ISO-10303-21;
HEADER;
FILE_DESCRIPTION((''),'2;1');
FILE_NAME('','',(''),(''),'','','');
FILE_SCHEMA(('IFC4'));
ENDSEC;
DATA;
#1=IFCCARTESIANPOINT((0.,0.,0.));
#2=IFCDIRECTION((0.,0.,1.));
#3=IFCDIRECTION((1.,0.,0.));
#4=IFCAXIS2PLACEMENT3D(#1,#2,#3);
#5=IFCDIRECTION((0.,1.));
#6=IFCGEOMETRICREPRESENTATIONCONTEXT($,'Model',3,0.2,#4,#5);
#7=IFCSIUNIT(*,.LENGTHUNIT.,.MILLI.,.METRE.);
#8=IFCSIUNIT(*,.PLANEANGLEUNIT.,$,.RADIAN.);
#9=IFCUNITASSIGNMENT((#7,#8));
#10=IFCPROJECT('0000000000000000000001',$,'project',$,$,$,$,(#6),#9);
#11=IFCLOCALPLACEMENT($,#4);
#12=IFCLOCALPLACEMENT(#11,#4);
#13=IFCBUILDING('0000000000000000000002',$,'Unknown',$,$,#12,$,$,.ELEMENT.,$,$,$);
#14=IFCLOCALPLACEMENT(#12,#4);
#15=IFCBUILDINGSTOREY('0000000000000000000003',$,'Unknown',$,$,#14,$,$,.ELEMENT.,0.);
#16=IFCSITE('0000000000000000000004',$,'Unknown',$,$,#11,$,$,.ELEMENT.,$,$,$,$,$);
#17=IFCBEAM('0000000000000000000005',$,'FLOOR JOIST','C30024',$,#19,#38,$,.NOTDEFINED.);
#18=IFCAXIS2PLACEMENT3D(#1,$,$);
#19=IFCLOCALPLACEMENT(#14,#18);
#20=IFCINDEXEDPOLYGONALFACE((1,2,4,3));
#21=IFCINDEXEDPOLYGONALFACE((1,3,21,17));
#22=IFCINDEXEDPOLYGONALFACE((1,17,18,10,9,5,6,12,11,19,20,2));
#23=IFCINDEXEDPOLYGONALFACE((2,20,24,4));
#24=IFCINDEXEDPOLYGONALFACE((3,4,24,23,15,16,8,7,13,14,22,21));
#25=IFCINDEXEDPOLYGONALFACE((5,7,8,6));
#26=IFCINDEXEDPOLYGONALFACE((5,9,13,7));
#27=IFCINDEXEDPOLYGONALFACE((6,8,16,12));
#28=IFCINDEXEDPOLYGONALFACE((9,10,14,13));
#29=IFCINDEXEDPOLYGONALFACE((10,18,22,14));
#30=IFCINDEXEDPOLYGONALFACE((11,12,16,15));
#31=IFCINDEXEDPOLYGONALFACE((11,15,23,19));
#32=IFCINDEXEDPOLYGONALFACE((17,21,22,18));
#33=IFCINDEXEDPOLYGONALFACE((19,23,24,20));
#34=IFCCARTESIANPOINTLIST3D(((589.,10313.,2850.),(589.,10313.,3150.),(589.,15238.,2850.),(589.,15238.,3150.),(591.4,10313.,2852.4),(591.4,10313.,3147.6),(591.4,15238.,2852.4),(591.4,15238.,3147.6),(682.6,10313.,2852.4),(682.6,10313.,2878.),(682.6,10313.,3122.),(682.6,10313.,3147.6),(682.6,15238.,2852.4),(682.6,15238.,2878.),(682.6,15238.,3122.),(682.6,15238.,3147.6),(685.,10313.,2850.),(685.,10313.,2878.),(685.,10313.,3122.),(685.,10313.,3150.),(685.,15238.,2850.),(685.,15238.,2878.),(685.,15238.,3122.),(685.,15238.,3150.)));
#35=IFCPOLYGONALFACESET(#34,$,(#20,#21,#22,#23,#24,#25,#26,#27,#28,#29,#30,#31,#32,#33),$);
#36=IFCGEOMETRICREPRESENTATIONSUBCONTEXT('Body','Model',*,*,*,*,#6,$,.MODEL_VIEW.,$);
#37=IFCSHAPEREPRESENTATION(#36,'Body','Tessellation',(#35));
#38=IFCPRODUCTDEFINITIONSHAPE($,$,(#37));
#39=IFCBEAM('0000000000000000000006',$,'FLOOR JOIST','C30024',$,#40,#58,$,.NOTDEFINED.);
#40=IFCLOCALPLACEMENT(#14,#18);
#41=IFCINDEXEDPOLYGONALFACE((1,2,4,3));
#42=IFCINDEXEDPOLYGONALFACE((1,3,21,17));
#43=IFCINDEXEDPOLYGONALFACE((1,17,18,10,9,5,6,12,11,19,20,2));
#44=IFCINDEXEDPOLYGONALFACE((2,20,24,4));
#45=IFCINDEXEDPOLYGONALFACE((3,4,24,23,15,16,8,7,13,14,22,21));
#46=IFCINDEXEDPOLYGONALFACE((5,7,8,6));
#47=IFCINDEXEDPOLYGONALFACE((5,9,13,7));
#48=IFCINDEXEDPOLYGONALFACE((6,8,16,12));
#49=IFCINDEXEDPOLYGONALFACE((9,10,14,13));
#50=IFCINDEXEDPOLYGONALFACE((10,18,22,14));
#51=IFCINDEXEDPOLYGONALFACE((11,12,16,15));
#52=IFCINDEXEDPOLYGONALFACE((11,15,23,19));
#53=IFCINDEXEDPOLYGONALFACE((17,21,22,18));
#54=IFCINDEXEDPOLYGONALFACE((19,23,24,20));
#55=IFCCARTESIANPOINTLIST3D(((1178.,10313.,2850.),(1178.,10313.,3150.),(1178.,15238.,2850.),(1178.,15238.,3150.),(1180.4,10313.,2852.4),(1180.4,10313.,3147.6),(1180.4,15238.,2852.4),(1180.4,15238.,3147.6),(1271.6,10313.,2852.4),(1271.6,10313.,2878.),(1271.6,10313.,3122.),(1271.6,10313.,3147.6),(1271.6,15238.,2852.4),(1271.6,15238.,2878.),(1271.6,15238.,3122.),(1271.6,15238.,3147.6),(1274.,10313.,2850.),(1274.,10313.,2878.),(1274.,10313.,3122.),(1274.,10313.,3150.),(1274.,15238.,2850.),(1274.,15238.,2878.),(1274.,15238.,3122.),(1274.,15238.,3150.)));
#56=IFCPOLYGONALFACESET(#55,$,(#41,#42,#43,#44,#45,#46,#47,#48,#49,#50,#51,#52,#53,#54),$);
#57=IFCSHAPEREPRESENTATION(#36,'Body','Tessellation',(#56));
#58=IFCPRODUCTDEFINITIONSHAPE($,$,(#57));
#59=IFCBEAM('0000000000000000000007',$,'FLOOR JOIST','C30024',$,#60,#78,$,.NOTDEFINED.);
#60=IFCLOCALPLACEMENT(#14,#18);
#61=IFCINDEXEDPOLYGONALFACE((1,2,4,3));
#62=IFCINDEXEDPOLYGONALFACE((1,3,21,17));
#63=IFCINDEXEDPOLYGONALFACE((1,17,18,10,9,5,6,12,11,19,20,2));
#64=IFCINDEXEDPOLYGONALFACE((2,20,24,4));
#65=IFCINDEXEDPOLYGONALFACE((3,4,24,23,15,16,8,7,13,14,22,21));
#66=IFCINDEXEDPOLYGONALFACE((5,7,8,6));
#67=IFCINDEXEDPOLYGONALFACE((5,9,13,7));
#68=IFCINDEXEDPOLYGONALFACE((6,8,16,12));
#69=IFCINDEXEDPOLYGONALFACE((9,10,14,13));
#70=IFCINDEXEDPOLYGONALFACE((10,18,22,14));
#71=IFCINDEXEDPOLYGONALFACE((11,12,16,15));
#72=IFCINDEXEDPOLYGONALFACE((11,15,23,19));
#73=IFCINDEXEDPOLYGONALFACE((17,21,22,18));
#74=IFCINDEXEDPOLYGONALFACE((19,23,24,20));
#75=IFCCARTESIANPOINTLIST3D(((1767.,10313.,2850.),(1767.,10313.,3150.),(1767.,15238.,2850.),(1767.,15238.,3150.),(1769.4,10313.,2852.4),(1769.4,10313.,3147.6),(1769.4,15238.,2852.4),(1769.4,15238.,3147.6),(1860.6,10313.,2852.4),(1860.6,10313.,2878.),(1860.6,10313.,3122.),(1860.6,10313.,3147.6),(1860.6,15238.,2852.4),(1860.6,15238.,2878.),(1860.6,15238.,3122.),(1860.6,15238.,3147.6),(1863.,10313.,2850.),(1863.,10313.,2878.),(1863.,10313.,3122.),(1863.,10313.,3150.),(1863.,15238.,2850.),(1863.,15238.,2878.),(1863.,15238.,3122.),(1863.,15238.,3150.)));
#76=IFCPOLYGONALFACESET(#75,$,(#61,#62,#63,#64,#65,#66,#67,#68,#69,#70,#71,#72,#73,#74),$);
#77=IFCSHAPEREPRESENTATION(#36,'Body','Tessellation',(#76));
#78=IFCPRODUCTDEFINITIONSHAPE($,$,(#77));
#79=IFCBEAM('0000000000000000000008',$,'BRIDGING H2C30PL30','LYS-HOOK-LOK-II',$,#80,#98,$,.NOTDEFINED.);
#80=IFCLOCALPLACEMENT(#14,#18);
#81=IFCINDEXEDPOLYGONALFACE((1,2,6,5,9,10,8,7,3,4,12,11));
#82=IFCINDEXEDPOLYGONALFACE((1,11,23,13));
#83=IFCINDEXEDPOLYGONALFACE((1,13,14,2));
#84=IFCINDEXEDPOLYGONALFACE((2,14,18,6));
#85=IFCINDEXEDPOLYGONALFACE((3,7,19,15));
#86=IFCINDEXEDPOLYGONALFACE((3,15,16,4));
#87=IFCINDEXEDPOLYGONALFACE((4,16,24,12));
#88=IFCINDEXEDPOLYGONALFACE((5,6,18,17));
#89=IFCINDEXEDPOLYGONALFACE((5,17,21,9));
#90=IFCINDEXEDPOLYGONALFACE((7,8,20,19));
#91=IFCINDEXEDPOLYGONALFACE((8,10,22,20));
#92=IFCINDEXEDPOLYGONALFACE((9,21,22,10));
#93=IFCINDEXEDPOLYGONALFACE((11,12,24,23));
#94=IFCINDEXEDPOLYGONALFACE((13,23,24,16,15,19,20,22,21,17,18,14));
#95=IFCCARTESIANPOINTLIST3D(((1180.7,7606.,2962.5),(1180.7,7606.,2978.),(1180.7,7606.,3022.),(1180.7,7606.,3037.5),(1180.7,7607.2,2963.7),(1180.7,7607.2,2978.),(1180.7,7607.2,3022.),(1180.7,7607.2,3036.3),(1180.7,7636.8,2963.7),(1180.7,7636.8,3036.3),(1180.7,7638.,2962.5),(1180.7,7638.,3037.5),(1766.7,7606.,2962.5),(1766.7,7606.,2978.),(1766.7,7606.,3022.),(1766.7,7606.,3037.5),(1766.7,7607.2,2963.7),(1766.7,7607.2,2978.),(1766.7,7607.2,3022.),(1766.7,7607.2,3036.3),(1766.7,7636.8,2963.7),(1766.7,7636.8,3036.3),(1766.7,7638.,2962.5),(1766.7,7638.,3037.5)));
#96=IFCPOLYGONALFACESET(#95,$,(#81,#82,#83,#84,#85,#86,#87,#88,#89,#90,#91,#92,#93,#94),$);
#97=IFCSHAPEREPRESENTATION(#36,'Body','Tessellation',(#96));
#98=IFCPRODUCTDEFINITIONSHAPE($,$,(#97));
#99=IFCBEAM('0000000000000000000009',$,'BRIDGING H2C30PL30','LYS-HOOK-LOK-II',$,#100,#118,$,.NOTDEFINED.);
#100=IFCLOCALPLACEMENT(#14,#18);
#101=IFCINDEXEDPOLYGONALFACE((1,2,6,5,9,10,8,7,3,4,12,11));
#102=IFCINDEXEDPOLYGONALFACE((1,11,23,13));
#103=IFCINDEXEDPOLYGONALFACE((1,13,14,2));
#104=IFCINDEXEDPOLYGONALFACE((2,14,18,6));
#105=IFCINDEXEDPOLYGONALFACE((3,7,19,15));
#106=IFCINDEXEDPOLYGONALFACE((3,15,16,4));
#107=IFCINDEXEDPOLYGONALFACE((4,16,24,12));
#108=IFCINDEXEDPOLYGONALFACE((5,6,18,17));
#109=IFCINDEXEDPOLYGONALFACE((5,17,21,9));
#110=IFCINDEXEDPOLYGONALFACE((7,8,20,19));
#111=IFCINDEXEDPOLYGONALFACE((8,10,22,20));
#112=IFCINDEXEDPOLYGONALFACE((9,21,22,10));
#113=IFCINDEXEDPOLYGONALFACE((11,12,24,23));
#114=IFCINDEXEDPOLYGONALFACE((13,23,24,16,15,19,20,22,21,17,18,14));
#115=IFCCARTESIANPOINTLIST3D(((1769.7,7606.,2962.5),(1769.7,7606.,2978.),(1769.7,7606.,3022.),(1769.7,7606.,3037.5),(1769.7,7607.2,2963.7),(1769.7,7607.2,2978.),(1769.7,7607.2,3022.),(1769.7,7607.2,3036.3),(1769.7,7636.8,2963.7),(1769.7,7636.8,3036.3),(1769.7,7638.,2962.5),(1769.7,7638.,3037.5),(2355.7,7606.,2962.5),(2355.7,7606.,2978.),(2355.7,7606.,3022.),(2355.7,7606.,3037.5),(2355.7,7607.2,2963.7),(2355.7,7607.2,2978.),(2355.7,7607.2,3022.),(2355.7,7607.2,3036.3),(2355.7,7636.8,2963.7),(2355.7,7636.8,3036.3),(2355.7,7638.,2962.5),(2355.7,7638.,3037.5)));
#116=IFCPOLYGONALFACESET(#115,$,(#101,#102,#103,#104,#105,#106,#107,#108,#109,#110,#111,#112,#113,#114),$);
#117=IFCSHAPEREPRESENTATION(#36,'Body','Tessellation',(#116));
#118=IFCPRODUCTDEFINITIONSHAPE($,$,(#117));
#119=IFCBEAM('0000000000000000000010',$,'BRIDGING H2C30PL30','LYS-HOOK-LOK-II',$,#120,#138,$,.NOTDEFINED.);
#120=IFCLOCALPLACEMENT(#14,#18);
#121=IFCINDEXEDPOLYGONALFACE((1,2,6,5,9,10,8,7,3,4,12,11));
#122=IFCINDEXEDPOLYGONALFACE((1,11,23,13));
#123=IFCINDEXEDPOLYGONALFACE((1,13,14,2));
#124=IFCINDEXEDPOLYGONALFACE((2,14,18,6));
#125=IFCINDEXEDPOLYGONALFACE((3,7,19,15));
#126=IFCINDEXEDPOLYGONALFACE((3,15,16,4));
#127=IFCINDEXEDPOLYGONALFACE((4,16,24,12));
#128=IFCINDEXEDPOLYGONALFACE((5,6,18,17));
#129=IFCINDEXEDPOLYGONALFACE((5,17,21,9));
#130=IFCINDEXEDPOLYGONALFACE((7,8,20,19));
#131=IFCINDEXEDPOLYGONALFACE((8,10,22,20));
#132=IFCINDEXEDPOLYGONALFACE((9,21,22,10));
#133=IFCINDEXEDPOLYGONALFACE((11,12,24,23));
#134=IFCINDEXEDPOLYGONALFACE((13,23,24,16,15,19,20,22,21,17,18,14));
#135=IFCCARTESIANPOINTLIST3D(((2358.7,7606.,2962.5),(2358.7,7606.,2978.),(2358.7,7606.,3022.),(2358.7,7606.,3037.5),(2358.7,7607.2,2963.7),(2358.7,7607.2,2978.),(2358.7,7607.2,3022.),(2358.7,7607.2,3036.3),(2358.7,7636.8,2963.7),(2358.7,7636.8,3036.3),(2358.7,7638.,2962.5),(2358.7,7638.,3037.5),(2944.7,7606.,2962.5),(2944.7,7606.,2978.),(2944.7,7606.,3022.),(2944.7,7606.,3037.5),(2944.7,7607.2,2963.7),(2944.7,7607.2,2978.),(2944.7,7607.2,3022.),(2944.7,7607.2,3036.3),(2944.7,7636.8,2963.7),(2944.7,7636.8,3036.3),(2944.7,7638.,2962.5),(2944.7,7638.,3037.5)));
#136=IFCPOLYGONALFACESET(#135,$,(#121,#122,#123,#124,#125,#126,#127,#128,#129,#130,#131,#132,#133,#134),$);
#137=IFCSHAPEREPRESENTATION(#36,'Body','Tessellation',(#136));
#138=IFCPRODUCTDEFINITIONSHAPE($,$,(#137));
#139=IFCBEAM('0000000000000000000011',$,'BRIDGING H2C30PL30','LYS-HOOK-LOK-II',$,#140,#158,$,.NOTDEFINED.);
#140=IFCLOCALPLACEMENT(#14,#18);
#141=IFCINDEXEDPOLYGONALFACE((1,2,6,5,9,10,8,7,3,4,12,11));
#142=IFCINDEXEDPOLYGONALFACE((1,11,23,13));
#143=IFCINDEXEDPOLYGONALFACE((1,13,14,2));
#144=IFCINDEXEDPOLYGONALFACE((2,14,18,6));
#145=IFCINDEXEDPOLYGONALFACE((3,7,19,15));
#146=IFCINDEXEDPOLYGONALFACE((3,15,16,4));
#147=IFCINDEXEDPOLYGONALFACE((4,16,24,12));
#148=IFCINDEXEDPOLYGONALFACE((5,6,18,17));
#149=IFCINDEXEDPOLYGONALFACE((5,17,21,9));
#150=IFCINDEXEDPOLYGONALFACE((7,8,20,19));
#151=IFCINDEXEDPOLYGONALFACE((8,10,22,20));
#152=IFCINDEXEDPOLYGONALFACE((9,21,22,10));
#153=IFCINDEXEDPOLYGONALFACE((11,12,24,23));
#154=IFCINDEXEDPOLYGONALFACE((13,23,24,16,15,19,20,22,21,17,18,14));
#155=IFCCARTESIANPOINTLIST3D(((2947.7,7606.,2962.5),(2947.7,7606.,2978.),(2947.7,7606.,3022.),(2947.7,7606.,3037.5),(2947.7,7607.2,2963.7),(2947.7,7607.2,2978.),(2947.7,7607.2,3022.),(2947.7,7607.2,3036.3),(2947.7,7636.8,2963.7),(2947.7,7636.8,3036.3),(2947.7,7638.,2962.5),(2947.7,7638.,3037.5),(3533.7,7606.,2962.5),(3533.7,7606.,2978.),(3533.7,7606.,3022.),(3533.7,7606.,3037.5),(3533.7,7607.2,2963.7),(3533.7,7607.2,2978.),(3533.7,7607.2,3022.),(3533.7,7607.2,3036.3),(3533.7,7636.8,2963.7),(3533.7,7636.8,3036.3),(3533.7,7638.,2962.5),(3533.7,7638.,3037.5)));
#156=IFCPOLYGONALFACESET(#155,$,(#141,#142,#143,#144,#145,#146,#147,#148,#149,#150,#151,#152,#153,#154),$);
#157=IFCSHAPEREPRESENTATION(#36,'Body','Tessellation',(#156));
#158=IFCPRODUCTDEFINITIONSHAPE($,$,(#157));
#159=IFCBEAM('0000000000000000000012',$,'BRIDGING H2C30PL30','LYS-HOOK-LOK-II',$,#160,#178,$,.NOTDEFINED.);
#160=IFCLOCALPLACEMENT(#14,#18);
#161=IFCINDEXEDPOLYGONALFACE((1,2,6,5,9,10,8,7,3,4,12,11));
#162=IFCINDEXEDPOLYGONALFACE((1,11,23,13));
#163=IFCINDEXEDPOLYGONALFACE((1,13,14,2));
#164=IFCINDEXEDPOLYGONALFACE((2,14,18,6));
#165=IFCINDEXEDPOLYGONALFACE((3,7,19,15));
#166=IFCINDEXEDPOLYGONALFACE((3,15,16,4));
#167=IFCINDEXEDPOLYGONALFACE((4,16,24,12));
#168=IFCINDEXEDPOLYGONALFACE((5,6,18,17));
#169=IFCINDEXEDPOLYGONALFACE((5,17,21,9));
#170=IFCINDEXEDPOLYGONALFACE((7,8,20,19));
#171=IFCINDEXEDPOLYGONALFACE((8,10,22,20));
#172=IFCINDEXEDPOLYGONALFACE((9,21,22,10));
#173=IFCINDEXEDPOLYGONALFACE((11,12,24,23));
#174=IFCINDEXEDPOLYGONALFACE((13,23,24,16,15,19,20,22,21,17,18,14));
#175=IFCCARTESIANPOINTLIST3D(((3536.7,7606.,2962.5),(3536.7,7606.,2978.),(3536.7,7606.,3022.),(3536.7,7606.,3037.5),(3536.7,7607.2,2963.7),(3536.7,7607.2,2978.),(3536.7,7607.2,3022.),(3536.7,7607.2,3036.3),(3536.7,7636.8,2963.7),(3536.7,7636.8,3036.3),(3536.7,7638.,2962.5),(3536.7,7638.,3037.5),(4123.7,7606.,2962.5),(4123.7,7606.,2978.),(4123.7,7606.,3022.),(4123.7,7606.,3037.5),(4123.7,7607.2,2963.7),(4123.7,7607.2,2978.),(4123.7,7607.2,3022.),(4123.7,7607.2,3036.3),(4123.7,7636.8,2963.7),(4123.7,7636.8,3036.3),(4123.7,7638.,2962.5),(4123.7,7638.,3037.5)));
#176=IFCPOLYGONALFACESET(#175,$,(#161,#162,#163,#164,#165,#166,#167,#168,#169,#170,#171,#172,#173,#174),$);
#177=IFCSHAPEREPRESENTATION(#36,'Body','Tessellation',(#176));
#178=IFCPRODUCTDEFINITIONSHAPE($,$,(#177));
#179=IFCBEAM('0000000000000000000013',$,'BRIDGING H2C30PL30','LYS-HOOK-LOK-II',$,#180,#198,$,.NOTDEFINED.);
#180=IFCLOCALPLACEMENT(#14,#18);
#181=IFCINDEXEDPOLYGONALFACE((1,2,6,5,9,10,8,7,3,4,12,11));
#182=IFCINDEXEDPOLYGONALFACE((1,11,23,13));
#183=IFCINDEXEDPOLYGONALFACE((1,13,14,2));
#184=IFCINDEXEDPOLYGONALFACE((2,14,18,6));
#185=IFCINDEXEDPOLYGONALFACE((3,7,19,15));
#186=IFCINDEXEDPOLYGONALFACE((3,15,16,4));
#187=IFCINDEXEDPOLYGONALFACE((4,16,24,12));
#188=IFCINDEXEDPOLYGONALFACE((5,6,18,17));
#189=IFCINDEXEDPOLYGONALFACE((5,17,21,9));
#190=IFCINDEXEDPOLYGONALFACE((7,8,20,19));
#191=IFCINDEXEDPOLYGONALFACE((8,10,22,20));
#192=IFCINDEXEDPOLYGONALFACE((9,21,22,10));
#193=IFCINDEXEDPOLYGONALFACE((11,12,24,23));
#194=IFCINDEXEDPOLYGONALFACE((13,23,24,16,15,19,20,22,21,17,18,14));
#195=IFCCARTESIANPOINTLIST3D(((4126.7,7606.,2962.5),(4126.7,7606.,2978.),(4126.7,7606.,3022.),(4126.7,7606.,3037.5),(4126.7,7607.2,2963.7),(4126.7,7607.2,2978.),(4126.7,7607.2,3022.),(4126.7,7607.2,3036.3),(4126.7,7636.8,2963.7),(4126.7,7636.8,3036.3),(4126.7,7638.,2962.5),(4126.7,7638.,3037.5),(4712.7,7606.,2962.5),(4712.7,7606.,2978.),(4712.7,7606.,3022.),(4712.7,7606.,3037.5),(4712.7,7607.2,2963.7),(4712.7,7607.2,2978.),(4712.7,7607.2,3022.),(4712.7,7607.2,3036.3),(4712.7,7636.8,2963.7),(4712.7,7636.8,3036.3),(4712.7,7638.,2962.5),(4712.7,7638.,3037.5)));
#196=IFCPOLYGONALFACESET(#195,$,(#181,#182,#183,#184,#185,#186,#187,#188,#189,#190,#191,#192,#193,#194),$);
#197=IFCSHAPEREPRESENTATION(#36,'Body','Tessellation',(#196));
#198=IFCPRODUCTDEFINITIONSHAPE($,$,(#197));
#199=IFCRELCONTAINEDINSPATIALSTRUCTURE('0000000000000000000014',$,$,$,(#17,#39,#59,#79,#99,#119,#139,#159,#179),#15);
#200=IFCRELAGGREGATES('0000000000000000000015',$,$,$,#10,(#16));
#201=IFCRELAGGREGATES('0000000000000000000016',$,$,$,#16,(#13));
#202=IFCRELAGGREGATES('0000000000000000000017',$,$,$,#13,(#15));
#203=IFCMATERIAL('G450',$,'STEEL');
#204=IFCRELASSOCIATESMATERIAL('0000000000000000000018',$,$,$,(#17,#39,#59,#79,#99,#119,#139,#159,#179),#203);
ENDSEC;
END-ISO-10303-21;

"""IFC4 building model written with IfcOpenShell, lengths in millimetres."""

from ifc_helpers import new_model, si_unit, direction, frame, origin_with_axes, place, context, subcontext, project, spatial, line, indexed_curve, outline, extrude, material, element, save


model = new_model("IFC4")

# Units and contexts
model_context = context("Model", 3, precision=0.2, world=origin_with_axes(), true_north=direction((0.0, 1.0)))
body_context = subcontext(model_context, "Body", "Model", "MODEL_VIEW")
ifc_project = project(units=[si_unit("LENGTHUNIT", "METRE", prefix="MILLI"), si_unit("PLANEANGLEUNIT", "RADIAN")], contexts=[model_context])

# Site, building, storey
site_placement = place(None, origin_with_axes())
site = spatial("IfcSite", under=ifc_project, at=site_placement, Name="Unknown", CompositionType="ELEMENT")
building_placement = place(site_placement, origin_with_axes())
building = spatial("IfcBuilding", under=site, at=building_placement, Name="Unknown", CompositionType="ELEMENT")
storey_placement = place(building_placement, origin_with_axes())
storey = spatial("IfcBuildingStorey", under=building, at=storey_placement, Name="Unknown", CompositionType="ELEMENT", Elevation=0.0)

# Beams
ifc_material_1 = material(Name="G450", Category="STEEL")
for number, where, z_axis, x_axis, name in (
    (1, (637.0, 10313.0, 3000.0), (1.0, 0.0, 0.0), (0.0, 1.0, 0.0), "FLOOR JOIST"),
    (2, (1226.0, 10313.0, 3000.0), (1.0, 0.0, 0.0), (0.0, 1.0, 0.0), "FLOOR JOIST"),
    (3, (1815.0, 10313.0, 3000.0), (1.0, 0.0, 0.0), (0.0, 1.0, 0.0), "FLOOR JOIST"),
):
    element("IfcBeam", number, at=place(storey_placement, frame(where, z_axis=z_axis, x_axis=x_axis)), inside=storey, material=ifc_material_1, Name=name, Description="C30024", PredefinedType="NOTDEFINED", context=body_context, shape_type="SolidModel", body=[
        extrude(outline(indexed_curve([(48.0, -150.0), (48.0, -122.0), (45.6, -122.0), (45.6, -147.6), (-45.6, -147.6), (-45.6, 147.6), (45.6, 147.6), (45.6, 122.0), (48.0, 122.0), (48.0, 150.0), (-48.0, 150.0), (-48.0, -150.0)], segments=[line(1, 2, 3, 4, 5, 6, 7, 8, 9, 10, 11, 12, 1)])), frame((0.0, 0.0, 0.0), z_axis=(-1.0, 0.0, 0.0), x_axis=(0.0, 0.0, 1.0)), (0.0, 0.0, -1.0), 4925.0),
    ])
for number, where, z_axis, x_axis, name in (
    (4, (1180.7, 7622.0, 3000.0), (0.0, -1.0, 0.0), (1.0, 0.0, 0.0), "BRIDGING H2C30PL30"),
    (5, (1769.7, 7622.0, 3000.0), (0.0, -1.0, 0.0), (1.0, 0.0, 0.0), "BRIDGING H2C30PL30"),
    (6, (2358.7, 7622.0, 3000.0), (0.0, -1.0, 0.0), (1.0, 0.0, 0.0), "BRIDGING H2C30PL30"),
    (7, (2947.7, 7622.0, 3000.0), (0.0, -1.0, 0.0), (1.0, 0.0, 0.0), "BRIDGING H2C30PL30"),
):
    element("IfcBeam", number, at=place(storey_placement, frame(where, z_axis=z_axis, x_axis=x_axis)), inside=storey, material=ifc_material_1, Name=name, Description="LYS-HOOK-LOK-II", PredefinedType="NOTDEFINED", context=body_context, shape_type="SolidModel", body=[
        extrude(outline(indexed_curve([(16.0, -37.5), (16.0, -22.0), (14.8, -22.0), (14.8, -36.3), (-14.8, -36.3), (-14.8, 36.3), (14.8, 36.3), (14.8, 22.0), (16.0, 22.0), (16.0, 37.5), (-16.0, 37.5), (-16.0, -37.5)], segments=[line(1, 2, 3, 4, 5, 6, 7, 8, 9, 10, 11, 12, 1)])), frame((0.0, 0.0, 0.0), z_axis=(-1.0, 0.0, 0.0), x_axis=(0.0, 0.0, 1.0)), (0.0, 0.0, -1.0), 586.0),
    ])
beam_placement = place(storey_placement, frame((3536.7, 7622.0, 3000.0), z_axis=(0.0, -1.0, 0.0), x_axis=(1.0, 0.0, 0.0)))
element("IfcBeam", 8, at=beam_placement, inside=storey, material=ifc_material_1, Name="BRIDGING H2C30PL30", Description="LYS-HOOK-LOK-II", PredefinedType="NOTDEFINED", context=body_context, shape_type="SolidModel", body=[
    extrude(outline(indexed_curve([(16.0, -37.5), (16.0, -22.0), (14.8, -22.0), (14.8, -36.3), (-14.8, -36.3), (-14.8, 36.3), (14.8, 36.3), (14.8, 22.0), (16.0, 22.0), (16.0, 37.5), (-16.0, 37.5), (-16.0, -37.5)], segments=[line(1, 2, 3, 4, 5, 6, 7, 8, 9, 10, 11, 12, 1)])), frame((0.0, 0.0, 0.0), z_axis=(-1.0, 0.0, 0.0), x_axis=(0.0, 0.0, 1.0)), (0.0, 0.0, -1.0), 587.0),
])
for number, where, z_axis, x_axis, name in (
    (9, (4126.7, 7622.0, 3000.0), (0.0, -1.0, 0.0), (1.0, 0.0, 0.0), "BRIDGING H2C30PL30"),
):
    element("IfcBeam", number, at=place(storey_placement, frame(where, z_axis=z_axis, x_axis=x_axis)), inside=storey, material=ifc_material_1, Name=name, Description="LYS-HOOK-LOK-II", PredefinedType="NOTDEFINED", context=body_context, shape_type="SolidModel", body=[
        extrude(outline(indexed_curve([(16.0, -37.5), (16.0, -22.0), (14.8, -22.0), (14.8, -36.3), (-14.8, -36.3), (-14.8, 36.3), (14.8, 36.3), (14.8, 22.0), (16.0, 22.0), (16.0, 37.5), (-16.0, 37.5), (-16.0, -37.5)], segments=[line(1, 2, 3, 4, 5, 6, 7, 8, 9, 10, 11, 12, 1)])), frame((0.0, 0.0, 0.0), z_axis=(-1.0, 0.0, 0.0), x_axis=(0.0, 0.0, 1.0)), (0.0, 0.0, -1.0), 586.0),
    ])

save(model, "model.ifc")
